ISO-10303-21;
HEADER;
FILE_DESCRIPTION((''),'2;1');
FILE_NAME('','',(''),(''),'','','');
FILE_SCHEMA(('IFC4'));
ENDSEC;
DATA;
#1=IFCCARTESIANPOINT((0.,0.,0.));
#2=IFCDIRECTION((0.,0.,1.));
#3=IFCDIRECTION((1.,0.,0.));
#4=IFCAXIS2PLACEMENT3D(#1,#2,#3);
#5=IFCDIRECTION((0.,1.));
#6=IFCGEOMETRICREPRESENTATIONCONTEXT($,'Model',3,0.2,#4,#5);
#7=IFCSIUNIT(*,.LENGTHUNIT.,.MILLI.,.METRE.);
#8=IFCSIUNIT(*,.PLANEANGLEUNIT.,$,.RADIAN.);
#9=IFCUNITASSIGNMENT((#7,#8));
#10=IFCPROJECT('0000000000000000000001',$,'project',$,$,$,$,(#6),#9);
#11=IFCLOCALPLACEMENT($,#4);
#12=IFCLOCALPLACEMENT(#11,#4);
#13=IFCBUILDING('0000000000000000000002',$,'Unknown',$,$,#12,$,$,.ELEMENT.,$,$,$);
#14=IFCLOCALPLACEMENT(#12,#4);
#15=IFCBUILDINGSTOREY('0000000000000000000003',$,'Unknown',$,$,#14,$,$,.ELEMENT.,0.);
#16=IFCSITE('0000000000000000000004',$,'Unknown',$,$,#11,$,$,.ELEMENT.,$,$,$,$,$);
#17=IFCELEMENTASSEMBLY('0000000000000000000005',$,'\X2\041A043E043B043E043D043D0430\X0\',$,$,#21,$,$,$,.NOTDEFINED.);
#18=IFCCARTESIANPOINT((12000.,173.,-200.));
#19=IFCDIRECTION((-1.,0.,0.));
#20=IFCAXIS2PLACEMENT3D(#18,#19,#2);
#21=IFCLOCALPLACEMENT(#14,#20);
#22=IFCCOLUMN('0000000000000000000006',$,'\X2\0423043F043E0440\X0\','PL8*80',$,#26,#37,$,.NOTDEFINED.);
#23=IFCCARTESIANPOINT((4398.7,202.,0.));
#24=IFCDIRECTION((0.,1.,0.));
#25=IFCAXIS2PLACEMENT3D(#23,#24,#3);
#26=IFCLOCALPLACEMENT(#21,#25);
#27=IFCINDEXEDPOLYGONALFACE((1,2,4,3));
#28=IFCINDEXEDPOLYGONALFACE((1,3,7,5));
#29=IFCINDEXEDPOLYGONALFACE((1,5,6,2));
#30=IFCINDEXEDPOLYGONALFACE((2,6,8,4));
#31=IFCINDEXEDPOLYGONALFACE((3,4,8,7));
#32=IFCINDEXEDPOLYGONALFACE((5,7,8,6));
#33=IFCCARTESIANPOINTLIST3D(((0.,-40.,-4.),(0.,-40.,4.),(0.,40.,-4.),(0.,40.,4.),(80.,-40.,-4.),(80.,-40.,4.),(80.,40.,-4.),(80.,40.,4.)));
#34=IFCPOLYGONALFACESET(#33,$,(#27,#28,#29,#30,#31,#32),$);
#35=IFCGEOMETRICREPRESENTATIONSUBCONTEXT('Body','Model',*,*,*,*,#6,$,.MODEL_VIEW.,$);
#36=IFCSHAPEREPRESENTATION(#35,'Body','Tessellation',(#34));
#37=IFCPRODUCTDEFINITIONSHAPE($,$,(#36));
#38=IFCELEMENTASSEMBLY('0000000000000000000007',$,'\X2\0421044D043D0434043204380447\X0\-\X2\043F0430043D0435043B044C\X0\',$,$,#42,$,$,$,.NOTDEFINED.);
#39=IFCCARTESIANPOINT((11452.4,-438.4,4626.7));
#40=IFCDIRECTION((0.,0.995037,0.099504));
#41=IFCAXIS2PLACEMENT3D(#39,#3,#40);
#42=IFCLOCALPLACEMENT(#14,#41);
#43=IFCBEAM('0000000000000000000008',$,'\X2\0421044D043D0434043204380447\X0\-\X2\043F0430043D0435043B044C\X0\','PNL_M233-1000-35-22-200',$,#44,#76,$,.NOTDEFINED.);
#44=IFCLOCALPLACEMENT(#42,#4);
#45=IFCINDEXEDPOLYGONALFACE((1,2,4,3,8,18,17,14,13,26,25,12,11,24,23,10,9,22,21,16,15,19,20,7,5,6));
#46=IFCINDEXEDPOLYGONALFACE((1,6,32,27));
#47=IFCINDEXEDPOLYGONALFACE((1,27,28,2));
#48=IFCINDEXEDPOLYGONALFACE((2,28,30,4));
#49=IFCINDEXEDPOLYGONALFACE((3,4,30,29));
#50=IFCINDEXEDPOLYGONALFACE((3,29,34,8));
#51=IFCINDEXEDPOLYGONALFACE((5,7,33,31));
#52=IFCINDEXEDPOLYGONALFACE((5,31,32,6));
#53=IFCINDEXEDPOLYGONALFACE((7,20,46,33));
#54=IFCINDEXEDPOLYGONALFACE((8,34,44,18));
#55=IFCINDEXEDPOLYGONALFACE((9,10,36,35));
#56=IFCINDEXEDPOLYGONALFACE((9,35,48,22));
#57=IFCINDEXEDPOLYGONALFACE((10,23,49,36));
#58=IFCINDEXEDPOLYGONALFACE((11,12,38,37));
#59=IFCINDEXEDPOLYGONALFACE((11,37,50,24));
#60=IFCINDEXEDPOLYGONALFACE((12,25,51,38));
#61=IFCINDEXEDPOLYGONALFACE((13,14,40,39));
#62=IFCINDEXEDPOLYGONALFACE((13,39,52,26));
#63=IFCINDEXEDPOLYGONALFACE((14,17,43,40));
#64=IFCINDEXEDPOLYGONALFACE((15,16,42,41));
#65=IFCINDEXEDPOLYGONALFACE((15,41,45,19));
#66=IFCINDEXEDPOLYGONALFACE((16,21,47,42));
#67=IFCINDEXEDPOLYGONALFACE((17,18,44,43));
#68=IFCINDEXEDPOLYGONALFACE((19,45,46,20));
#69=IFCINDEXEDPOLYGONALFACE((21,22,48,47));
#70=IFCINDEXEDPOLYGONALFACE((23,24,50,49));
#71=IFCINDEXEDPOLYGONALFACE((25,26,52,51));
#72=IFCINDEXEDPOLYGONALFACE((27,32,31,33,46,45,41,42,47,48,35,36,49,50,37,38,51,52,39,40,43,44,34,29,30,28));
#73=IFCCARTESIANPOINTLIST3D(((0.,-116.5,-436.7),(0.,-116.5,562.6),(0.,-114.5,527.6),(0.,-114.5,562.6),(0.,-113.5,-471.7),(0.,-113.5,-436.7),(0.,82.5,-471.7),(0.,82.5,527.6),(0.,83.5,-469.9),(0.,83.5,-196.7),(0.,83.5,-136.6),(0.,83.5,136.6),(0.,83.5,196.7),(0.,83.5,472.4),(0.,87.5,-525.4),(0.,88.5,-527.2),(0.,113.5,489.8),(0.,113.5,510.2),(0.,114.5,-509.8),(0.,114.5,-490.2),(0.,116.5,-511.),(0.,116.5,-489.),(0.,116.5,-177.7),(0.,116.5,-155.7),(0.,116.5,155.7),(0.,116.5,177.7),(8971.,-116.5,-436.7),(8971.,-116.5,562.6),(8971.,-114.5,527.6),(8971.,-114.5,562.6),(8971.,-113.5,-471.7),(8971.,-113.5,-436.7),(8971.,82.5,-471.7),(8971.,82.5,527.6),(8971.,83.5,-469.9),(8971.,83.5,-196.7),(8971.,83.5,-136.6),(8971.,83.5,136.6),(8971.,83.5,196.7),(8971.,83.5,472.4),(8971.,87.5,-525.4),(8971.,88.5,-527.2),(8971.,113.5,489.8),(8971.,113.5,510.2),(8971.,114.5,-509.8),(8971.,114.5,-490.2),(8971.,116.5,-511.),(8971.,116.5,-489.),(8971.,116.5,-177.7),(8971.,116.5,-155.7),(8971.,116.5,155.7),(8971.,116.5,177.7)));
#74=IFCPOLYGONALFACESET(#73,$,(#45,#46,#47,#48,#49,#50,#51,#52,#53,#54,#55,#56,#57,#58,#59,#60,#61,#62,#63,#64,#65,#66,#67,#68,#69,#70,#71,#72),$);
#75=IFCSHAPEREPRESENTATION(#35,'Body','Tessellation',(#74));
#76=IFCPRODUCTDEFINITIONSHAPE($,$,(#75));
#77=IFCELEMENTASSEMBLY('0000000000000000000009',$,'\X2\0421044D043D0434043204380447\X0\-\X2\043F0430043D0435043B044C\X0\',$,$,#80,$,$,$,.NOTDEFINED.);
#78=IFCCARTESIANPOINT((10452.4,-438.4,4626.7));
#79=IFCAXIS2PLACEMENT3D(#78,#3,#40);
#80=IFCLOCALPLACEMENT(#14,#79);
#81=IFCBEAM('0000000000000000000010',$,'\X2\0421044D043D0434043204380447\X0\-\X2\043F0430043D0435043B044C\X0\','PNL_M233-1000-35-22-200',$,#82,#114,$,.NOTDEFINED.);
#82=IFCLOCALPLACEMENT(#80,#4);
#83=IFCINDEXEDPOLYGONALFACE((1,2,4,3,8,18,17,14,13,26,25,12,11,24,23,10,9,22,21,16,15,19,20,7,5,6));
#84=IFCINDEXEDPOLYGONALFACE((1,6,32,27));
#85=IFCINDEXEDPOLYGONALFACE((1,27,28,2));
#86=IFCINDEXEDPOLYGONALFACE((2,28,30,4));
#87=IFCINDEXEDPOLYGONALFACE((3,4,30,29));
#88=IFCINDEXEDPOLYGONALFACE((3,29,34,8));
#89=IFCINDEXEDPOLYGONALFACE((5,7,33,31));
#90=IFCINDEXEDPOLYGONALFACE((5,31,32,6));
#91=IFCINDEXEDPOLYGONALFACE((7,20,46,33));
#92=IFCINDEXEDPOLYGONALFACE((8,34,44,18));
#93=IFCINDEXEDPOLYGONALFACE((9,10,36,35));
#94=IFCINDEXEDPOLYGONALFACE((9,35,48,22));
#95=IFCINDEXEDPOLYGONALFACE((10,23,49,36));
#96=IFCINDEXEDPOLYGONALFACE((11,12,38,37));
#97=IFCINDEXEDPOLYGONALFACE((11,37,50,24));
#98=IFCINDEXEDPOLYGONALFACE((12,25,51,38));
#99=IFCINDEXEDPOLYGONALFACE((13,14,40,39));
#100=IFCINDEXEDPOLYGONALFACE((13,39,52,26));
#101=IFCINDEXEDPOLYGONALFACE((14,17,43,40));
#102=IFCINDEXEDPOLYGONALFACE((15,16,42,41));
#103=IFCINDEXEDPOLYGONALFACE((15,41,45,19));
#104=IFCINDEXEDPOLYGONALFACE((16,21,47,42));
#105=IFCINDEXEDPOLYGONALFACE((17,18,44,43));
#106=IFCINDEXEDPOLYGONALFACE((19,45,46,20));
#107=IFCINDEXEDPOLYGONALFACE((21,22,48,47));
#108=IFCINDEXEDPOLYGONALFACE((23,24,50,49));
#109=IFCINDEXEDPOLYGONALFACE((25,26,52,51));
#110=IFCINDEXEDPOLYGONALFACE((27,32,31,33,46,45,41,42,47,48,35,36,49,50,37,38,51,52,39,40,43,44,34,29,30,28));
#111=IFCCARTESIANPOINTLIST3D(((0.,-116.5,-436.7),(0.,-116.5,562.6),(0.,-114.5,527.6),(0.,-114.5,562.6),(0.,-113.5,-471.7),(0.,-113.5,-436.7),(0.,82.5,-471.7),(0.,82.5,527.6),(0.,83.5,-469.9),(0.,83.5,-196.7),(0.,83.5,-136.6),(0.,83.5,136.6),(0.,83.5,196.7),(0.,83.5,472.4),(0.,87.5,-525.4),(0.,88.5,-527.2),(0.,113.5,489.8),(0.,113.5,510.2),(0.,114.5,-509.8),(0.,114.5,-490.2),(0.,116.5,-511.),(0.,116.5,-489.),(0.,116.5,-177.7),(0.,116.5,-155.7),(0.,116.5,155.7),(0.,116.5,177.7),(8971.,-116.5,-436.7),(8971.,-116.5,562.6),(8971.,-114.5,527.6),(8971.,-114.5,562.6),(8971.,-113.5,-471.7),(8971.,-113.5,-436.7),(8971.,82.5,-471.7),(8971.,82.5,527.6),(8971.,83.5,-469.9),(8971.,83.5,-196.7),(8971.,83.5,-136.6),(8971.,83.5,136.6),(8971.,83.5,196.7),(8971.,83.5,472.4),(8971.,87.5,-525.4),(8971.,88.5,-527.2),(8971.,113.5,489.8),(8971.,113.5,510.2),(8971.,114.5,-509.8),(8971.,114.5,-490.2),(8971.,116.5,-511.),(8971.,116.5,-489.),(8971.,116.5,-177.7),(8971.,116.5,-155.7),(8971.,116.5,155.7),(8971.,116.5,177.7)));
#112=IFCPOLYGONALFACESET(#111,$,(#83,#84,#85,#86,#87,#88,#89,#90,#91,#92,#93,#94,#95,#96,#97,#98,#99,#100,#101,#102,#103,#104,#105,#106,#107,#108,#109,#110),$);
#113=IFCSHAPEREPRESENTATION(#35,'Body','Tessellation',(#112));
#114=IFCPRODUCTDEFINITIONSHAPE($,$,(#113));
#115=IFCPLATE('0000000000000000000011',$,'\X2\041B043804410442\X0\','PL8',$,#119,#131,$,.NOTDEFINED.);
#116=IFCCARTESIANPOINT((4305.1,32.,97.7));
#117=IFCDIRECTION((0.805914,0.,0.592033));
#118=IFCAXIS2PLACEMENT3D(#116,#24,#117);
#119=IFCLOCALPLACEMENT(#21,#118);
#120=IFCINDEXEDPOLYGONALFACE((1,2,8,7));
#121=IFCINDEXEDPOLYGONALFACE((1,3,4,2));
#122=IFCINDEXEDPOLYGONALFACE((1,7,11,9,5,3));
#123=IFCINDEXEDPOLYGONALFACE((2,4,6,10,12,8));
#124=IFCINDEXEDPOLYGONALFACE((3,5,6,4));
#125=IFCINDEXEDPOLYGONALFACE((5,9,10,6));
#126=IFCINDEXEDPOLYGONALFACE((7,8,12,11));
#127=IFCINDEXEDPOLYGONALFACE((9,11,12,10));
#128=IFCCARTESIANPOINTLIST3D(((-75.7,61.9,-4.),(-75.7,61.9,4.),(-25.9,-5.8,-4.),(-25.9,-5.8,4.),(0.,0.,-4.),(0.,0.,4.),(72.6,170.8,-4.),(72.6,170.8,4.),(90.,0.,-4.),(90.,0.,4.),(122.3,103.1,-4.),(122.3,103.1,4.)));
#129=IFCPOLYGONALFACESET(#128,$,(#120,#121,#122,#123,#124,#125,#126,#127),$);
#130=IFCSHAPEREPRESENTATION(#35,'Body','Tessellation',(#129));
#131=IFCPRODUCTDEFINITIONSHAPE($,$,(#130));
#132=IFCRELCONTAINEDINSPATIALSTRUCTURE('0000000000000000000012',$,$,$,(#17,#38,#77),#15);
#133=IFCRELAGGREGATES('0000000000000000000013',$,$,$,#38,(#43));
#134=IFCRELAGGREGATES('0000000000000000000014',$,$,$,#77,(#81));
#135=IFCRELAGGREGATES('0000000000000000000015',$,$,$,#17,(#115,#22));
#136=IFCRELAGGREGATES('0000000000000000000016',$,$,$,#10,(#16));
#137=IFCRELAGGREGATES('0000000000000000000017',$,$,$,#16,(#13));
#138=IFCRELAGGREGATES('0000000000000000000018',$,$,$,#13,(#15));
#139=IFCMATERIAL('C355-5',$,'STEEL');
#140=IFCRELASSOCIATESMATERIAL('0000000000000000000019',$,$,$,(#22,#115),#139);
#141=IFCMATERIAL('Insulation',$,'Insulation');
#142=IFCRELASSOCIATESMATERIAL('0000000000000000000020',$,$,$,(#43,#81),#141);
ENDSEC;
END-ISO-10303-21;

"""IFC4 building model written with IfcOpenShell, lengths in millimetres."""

from ifc_helpers import new_model, si_unit, direction, frame, origin_with_axes, place, context, subcontext, project, spatial, line, indexed_curve, outline, extrude, material, element, aggregate, save


model = new_model("IFC4")

# Units and contexts
model_context = context("Model", 3, precision=0.2, world=origin_with_axes(), true_north=direction((0.0, 1.0)))
body_context = subcontext(model_context, "Body", "Model", "MODEL_VIEW")
ifc_project = project(units=[si_unit("LENGTHUNIT", "METRE", prefix="MILLI"), si_unit("PLANEANGLEUNIT", "RADIAN")], contexts=[model_context])

# Site, building, storey
site_placement = place(None, origin_with_axes())
site = spatial("IfcSite", under=ifc_project, at=site_placement, Name="Unknown", CompositionType="ELEMENT")
building_placement = place(site_placement, origin_with_axes())
building = spatial("IfcBuilding", under=site, at=building_placement, Name="Unknown", CompositionType="ELEMENT")
storey_placement = place(building_placement, origin_with_axes())
storey = spatial("IfcBuildingStorey", under=building, at=storey_placement, Name="Unknown", CompositionType="ELEMENT", Elevation=0.0)

# Element assembly, column
assembly_1_placement = place(storey_placement, frame((12000.0, 173.0, -200.0), z_axis=(-1.0, 0.0, 0.0), x_axis=(0.0, 0.0, 1.0)))
assembly_1 = element("IfcElementAssembly", 1, at=assembly_1_placement, inside=storey, Name="Колонна", PredefinedType="NOTDEFINED")
ifc_material_1 = material(Name="C355-5", Category="STEEL")
column_1_placement = place(assembly_1_placement, frame((4398.7, 202.0, 0.0), z_axis=(0.0, 1.0, 0.0), x_axis=(1.0, 0.0, 0.0)))
column_1 = element("IfcColumn", 2, at=column_1_placement, material=ifc_material_1, Name="Упор", Description="PL8*80", PredefinedType="NOTDEFINED", context=body_context, shape_type="SolidModel", body=[
    extrude(outline(indexed_curve([(-4.0, -40.0), (4.0, -40.0), (4.0, 40.0), (-4.0, 40.0)], segments=[line(1, 2, 3, 4, 1)])), frame((0.0, 0.0, 0.0), z_axis=(-1.0, 0.0, 0.0), x_axis=(0.0, 0.0, 1.0)), (0.0, 0.0, -1.0), 80.0),
])

# Element assemblies, beams
assembly_2_placement = place(storey_placement, frame((11452.4, -438.4, 4626.7), z_axis=(1.0, 0.0, 0.0), x_axis=(0.0, 0.995037, 0.099504)))
assembly_2 = element("IfcElementAssembly", 3, at=assembly_2_placement, inside=storey, Name="Сэндвич-панель", PredefinedType="NOTDEFINED")
ifc_material_2 = material(Name="Insulation", Category="Insulation")
beam_1_placement = place(assembly_2_placement, origin_with_axes())
beam_1 = element("IfcBeam", 4, at=beam_1_placement, material=ifc_material_2, Name="Сэндвич-панель", Description="PNL_M233-1000-35-22-200", PredefinedType="NOTDEFINED", context=body_context, shape_type="SolidModel", body=[
    extrude(outline(indexed_curve([(-509.8, 114.5), (-490.2, 114.5), (-471.7, 82.5), (-471.7, -113.5), (-436.7, -113.5), (-436.7, -116.5), (562.6, -116.5), (562.6, -114.5), (527.6, -114.5), (527.6, 82.5), (510.2, 113.5), (489.8, 113.5), (472.4, 83.5), (196.7, 83.5), (177.7, 116.5), (155.7, 116.5), (136.6, 83.5), (-136.6, 83.5), (-155.7, 116.5), (-177.7, 116.5), (-196.7, 83.5), (-469.9, 83.5), (-489.0, 116.5), (-511.0, 116.5), (-527.2, 88.5), (-525.4, 87.5)], segments=[line(1, 2, 3, 4, 5, 6, 7, 8, 9, 10, 11, 12, 13, 14, 15, 16, 17, 18, 19, 20, 21, 22, 23, 24, 25, 26, 1)])), frame((0.0, 0.0, 0.0), z_axis=(-1.0, 0.0, 0.0), x_axis=(0.0, 0.0, 1.0)), (0.0, 0.0, -1.0), 8971.0),
])
aggregate(assembly_2, [beam_1])
assembly_3_placement = place(storey_placement, frame((10452.4, -438.4, 4626.7), z_axis=(1.0, 0.0, 0.0), x_axis=(0.0, 0.995037, 0.099504)))
assembly_3 = element("IfcElementAssembly", 5, at=assembly_3_placement, inside=storey, Name="Сэндвич-панель", PredefinedType="NOTDEFINED")
beam_2_placement = place(assembly_3_placement, origin_with_axes())
beam_2 = element("IfcBeam", 6, at=beam_2_placement, material=ifc_material_2, Name="Сэндвич-панель", Description="PNL_M233-1000-35-22-200", PredefinedType="NOTDEFINED", context=body_context, shape_type="SolidModel", body=[
    extrude(outline(indexed_curve([(-509.8, 114.5), (-490.2, 114.5), (-471.7, 82.5), (-471.7, -113.5), (-436.7, -113.5), (-436.7, -116.5), (562.6, -116.5), (562.6, -114.5), (527.6, -114.5), (527.6, 82.5), (510.2, 113.5), (489.8, 113.5), (472.4, 83.5), (196.7, 83.5), (177.7, 116.5), (155.7, 116.5), (136.6, 83.5), (-136.6, 83.5), (-155.7, 116.5), (-177.7, 116.5), (-196.7, 83.5), (-469.9, 83.5), (-489.0, 116.5), (-511.0, 116.5), (-527.2, 88.5), (-525.4, 87.5)], segments=[line(1, 2, 3, 4, 5, 6, 7, 8, 9, 10, 11, 12, 13, 14, 15, 16, 17, 18, 19, 20, 21, 22, 23, 24, 25, 26, 1)])), frame((0.0, 0.0, 0.0), z_axis=(-1.0, 0.0, 0.0), x_axis=(0.0, 0.0, 1.0)), (0.0, 0.0, -1.0), 8971.0),
])
aggregate(assembly_3, [beam_2])

# Plate
plate_1_placement = place(assembly_1_placement, frame((4305.1, 32.0, 97.7), z_axis=(0.0, 1.0, 0.0), x_axis=(0.805914, 0.0, 0.592033)))
plate_1 = element("IfcPlate", 7, at=plate_1_placement, material=ifc_material_1, Name="Лист", Description="PL8", PredefinedType="NOTDEFINED", context=body_context, shape_type="SolidModel", body=[
    extrude(outline(indexed_curve([(0.0, 0.0), (90.0, 0.0), (122.3, 103.1), (72.6, 170.8), (-75.7, 61.9), (-25.9, -5.8)], segments=[line(1, 2, 3, 4, 5, 6, 1)])), frame((0.0, 0.0, 4.0), z_axis=(0.0, 0.0, 1.0), x_axis=(1.0, 0.0, 0.0)), (0.0, 0.0, -1.0), 8.0),
])
aggregate(assembly_1, [plate_1, column_1])

save(model, "model.ifc")
